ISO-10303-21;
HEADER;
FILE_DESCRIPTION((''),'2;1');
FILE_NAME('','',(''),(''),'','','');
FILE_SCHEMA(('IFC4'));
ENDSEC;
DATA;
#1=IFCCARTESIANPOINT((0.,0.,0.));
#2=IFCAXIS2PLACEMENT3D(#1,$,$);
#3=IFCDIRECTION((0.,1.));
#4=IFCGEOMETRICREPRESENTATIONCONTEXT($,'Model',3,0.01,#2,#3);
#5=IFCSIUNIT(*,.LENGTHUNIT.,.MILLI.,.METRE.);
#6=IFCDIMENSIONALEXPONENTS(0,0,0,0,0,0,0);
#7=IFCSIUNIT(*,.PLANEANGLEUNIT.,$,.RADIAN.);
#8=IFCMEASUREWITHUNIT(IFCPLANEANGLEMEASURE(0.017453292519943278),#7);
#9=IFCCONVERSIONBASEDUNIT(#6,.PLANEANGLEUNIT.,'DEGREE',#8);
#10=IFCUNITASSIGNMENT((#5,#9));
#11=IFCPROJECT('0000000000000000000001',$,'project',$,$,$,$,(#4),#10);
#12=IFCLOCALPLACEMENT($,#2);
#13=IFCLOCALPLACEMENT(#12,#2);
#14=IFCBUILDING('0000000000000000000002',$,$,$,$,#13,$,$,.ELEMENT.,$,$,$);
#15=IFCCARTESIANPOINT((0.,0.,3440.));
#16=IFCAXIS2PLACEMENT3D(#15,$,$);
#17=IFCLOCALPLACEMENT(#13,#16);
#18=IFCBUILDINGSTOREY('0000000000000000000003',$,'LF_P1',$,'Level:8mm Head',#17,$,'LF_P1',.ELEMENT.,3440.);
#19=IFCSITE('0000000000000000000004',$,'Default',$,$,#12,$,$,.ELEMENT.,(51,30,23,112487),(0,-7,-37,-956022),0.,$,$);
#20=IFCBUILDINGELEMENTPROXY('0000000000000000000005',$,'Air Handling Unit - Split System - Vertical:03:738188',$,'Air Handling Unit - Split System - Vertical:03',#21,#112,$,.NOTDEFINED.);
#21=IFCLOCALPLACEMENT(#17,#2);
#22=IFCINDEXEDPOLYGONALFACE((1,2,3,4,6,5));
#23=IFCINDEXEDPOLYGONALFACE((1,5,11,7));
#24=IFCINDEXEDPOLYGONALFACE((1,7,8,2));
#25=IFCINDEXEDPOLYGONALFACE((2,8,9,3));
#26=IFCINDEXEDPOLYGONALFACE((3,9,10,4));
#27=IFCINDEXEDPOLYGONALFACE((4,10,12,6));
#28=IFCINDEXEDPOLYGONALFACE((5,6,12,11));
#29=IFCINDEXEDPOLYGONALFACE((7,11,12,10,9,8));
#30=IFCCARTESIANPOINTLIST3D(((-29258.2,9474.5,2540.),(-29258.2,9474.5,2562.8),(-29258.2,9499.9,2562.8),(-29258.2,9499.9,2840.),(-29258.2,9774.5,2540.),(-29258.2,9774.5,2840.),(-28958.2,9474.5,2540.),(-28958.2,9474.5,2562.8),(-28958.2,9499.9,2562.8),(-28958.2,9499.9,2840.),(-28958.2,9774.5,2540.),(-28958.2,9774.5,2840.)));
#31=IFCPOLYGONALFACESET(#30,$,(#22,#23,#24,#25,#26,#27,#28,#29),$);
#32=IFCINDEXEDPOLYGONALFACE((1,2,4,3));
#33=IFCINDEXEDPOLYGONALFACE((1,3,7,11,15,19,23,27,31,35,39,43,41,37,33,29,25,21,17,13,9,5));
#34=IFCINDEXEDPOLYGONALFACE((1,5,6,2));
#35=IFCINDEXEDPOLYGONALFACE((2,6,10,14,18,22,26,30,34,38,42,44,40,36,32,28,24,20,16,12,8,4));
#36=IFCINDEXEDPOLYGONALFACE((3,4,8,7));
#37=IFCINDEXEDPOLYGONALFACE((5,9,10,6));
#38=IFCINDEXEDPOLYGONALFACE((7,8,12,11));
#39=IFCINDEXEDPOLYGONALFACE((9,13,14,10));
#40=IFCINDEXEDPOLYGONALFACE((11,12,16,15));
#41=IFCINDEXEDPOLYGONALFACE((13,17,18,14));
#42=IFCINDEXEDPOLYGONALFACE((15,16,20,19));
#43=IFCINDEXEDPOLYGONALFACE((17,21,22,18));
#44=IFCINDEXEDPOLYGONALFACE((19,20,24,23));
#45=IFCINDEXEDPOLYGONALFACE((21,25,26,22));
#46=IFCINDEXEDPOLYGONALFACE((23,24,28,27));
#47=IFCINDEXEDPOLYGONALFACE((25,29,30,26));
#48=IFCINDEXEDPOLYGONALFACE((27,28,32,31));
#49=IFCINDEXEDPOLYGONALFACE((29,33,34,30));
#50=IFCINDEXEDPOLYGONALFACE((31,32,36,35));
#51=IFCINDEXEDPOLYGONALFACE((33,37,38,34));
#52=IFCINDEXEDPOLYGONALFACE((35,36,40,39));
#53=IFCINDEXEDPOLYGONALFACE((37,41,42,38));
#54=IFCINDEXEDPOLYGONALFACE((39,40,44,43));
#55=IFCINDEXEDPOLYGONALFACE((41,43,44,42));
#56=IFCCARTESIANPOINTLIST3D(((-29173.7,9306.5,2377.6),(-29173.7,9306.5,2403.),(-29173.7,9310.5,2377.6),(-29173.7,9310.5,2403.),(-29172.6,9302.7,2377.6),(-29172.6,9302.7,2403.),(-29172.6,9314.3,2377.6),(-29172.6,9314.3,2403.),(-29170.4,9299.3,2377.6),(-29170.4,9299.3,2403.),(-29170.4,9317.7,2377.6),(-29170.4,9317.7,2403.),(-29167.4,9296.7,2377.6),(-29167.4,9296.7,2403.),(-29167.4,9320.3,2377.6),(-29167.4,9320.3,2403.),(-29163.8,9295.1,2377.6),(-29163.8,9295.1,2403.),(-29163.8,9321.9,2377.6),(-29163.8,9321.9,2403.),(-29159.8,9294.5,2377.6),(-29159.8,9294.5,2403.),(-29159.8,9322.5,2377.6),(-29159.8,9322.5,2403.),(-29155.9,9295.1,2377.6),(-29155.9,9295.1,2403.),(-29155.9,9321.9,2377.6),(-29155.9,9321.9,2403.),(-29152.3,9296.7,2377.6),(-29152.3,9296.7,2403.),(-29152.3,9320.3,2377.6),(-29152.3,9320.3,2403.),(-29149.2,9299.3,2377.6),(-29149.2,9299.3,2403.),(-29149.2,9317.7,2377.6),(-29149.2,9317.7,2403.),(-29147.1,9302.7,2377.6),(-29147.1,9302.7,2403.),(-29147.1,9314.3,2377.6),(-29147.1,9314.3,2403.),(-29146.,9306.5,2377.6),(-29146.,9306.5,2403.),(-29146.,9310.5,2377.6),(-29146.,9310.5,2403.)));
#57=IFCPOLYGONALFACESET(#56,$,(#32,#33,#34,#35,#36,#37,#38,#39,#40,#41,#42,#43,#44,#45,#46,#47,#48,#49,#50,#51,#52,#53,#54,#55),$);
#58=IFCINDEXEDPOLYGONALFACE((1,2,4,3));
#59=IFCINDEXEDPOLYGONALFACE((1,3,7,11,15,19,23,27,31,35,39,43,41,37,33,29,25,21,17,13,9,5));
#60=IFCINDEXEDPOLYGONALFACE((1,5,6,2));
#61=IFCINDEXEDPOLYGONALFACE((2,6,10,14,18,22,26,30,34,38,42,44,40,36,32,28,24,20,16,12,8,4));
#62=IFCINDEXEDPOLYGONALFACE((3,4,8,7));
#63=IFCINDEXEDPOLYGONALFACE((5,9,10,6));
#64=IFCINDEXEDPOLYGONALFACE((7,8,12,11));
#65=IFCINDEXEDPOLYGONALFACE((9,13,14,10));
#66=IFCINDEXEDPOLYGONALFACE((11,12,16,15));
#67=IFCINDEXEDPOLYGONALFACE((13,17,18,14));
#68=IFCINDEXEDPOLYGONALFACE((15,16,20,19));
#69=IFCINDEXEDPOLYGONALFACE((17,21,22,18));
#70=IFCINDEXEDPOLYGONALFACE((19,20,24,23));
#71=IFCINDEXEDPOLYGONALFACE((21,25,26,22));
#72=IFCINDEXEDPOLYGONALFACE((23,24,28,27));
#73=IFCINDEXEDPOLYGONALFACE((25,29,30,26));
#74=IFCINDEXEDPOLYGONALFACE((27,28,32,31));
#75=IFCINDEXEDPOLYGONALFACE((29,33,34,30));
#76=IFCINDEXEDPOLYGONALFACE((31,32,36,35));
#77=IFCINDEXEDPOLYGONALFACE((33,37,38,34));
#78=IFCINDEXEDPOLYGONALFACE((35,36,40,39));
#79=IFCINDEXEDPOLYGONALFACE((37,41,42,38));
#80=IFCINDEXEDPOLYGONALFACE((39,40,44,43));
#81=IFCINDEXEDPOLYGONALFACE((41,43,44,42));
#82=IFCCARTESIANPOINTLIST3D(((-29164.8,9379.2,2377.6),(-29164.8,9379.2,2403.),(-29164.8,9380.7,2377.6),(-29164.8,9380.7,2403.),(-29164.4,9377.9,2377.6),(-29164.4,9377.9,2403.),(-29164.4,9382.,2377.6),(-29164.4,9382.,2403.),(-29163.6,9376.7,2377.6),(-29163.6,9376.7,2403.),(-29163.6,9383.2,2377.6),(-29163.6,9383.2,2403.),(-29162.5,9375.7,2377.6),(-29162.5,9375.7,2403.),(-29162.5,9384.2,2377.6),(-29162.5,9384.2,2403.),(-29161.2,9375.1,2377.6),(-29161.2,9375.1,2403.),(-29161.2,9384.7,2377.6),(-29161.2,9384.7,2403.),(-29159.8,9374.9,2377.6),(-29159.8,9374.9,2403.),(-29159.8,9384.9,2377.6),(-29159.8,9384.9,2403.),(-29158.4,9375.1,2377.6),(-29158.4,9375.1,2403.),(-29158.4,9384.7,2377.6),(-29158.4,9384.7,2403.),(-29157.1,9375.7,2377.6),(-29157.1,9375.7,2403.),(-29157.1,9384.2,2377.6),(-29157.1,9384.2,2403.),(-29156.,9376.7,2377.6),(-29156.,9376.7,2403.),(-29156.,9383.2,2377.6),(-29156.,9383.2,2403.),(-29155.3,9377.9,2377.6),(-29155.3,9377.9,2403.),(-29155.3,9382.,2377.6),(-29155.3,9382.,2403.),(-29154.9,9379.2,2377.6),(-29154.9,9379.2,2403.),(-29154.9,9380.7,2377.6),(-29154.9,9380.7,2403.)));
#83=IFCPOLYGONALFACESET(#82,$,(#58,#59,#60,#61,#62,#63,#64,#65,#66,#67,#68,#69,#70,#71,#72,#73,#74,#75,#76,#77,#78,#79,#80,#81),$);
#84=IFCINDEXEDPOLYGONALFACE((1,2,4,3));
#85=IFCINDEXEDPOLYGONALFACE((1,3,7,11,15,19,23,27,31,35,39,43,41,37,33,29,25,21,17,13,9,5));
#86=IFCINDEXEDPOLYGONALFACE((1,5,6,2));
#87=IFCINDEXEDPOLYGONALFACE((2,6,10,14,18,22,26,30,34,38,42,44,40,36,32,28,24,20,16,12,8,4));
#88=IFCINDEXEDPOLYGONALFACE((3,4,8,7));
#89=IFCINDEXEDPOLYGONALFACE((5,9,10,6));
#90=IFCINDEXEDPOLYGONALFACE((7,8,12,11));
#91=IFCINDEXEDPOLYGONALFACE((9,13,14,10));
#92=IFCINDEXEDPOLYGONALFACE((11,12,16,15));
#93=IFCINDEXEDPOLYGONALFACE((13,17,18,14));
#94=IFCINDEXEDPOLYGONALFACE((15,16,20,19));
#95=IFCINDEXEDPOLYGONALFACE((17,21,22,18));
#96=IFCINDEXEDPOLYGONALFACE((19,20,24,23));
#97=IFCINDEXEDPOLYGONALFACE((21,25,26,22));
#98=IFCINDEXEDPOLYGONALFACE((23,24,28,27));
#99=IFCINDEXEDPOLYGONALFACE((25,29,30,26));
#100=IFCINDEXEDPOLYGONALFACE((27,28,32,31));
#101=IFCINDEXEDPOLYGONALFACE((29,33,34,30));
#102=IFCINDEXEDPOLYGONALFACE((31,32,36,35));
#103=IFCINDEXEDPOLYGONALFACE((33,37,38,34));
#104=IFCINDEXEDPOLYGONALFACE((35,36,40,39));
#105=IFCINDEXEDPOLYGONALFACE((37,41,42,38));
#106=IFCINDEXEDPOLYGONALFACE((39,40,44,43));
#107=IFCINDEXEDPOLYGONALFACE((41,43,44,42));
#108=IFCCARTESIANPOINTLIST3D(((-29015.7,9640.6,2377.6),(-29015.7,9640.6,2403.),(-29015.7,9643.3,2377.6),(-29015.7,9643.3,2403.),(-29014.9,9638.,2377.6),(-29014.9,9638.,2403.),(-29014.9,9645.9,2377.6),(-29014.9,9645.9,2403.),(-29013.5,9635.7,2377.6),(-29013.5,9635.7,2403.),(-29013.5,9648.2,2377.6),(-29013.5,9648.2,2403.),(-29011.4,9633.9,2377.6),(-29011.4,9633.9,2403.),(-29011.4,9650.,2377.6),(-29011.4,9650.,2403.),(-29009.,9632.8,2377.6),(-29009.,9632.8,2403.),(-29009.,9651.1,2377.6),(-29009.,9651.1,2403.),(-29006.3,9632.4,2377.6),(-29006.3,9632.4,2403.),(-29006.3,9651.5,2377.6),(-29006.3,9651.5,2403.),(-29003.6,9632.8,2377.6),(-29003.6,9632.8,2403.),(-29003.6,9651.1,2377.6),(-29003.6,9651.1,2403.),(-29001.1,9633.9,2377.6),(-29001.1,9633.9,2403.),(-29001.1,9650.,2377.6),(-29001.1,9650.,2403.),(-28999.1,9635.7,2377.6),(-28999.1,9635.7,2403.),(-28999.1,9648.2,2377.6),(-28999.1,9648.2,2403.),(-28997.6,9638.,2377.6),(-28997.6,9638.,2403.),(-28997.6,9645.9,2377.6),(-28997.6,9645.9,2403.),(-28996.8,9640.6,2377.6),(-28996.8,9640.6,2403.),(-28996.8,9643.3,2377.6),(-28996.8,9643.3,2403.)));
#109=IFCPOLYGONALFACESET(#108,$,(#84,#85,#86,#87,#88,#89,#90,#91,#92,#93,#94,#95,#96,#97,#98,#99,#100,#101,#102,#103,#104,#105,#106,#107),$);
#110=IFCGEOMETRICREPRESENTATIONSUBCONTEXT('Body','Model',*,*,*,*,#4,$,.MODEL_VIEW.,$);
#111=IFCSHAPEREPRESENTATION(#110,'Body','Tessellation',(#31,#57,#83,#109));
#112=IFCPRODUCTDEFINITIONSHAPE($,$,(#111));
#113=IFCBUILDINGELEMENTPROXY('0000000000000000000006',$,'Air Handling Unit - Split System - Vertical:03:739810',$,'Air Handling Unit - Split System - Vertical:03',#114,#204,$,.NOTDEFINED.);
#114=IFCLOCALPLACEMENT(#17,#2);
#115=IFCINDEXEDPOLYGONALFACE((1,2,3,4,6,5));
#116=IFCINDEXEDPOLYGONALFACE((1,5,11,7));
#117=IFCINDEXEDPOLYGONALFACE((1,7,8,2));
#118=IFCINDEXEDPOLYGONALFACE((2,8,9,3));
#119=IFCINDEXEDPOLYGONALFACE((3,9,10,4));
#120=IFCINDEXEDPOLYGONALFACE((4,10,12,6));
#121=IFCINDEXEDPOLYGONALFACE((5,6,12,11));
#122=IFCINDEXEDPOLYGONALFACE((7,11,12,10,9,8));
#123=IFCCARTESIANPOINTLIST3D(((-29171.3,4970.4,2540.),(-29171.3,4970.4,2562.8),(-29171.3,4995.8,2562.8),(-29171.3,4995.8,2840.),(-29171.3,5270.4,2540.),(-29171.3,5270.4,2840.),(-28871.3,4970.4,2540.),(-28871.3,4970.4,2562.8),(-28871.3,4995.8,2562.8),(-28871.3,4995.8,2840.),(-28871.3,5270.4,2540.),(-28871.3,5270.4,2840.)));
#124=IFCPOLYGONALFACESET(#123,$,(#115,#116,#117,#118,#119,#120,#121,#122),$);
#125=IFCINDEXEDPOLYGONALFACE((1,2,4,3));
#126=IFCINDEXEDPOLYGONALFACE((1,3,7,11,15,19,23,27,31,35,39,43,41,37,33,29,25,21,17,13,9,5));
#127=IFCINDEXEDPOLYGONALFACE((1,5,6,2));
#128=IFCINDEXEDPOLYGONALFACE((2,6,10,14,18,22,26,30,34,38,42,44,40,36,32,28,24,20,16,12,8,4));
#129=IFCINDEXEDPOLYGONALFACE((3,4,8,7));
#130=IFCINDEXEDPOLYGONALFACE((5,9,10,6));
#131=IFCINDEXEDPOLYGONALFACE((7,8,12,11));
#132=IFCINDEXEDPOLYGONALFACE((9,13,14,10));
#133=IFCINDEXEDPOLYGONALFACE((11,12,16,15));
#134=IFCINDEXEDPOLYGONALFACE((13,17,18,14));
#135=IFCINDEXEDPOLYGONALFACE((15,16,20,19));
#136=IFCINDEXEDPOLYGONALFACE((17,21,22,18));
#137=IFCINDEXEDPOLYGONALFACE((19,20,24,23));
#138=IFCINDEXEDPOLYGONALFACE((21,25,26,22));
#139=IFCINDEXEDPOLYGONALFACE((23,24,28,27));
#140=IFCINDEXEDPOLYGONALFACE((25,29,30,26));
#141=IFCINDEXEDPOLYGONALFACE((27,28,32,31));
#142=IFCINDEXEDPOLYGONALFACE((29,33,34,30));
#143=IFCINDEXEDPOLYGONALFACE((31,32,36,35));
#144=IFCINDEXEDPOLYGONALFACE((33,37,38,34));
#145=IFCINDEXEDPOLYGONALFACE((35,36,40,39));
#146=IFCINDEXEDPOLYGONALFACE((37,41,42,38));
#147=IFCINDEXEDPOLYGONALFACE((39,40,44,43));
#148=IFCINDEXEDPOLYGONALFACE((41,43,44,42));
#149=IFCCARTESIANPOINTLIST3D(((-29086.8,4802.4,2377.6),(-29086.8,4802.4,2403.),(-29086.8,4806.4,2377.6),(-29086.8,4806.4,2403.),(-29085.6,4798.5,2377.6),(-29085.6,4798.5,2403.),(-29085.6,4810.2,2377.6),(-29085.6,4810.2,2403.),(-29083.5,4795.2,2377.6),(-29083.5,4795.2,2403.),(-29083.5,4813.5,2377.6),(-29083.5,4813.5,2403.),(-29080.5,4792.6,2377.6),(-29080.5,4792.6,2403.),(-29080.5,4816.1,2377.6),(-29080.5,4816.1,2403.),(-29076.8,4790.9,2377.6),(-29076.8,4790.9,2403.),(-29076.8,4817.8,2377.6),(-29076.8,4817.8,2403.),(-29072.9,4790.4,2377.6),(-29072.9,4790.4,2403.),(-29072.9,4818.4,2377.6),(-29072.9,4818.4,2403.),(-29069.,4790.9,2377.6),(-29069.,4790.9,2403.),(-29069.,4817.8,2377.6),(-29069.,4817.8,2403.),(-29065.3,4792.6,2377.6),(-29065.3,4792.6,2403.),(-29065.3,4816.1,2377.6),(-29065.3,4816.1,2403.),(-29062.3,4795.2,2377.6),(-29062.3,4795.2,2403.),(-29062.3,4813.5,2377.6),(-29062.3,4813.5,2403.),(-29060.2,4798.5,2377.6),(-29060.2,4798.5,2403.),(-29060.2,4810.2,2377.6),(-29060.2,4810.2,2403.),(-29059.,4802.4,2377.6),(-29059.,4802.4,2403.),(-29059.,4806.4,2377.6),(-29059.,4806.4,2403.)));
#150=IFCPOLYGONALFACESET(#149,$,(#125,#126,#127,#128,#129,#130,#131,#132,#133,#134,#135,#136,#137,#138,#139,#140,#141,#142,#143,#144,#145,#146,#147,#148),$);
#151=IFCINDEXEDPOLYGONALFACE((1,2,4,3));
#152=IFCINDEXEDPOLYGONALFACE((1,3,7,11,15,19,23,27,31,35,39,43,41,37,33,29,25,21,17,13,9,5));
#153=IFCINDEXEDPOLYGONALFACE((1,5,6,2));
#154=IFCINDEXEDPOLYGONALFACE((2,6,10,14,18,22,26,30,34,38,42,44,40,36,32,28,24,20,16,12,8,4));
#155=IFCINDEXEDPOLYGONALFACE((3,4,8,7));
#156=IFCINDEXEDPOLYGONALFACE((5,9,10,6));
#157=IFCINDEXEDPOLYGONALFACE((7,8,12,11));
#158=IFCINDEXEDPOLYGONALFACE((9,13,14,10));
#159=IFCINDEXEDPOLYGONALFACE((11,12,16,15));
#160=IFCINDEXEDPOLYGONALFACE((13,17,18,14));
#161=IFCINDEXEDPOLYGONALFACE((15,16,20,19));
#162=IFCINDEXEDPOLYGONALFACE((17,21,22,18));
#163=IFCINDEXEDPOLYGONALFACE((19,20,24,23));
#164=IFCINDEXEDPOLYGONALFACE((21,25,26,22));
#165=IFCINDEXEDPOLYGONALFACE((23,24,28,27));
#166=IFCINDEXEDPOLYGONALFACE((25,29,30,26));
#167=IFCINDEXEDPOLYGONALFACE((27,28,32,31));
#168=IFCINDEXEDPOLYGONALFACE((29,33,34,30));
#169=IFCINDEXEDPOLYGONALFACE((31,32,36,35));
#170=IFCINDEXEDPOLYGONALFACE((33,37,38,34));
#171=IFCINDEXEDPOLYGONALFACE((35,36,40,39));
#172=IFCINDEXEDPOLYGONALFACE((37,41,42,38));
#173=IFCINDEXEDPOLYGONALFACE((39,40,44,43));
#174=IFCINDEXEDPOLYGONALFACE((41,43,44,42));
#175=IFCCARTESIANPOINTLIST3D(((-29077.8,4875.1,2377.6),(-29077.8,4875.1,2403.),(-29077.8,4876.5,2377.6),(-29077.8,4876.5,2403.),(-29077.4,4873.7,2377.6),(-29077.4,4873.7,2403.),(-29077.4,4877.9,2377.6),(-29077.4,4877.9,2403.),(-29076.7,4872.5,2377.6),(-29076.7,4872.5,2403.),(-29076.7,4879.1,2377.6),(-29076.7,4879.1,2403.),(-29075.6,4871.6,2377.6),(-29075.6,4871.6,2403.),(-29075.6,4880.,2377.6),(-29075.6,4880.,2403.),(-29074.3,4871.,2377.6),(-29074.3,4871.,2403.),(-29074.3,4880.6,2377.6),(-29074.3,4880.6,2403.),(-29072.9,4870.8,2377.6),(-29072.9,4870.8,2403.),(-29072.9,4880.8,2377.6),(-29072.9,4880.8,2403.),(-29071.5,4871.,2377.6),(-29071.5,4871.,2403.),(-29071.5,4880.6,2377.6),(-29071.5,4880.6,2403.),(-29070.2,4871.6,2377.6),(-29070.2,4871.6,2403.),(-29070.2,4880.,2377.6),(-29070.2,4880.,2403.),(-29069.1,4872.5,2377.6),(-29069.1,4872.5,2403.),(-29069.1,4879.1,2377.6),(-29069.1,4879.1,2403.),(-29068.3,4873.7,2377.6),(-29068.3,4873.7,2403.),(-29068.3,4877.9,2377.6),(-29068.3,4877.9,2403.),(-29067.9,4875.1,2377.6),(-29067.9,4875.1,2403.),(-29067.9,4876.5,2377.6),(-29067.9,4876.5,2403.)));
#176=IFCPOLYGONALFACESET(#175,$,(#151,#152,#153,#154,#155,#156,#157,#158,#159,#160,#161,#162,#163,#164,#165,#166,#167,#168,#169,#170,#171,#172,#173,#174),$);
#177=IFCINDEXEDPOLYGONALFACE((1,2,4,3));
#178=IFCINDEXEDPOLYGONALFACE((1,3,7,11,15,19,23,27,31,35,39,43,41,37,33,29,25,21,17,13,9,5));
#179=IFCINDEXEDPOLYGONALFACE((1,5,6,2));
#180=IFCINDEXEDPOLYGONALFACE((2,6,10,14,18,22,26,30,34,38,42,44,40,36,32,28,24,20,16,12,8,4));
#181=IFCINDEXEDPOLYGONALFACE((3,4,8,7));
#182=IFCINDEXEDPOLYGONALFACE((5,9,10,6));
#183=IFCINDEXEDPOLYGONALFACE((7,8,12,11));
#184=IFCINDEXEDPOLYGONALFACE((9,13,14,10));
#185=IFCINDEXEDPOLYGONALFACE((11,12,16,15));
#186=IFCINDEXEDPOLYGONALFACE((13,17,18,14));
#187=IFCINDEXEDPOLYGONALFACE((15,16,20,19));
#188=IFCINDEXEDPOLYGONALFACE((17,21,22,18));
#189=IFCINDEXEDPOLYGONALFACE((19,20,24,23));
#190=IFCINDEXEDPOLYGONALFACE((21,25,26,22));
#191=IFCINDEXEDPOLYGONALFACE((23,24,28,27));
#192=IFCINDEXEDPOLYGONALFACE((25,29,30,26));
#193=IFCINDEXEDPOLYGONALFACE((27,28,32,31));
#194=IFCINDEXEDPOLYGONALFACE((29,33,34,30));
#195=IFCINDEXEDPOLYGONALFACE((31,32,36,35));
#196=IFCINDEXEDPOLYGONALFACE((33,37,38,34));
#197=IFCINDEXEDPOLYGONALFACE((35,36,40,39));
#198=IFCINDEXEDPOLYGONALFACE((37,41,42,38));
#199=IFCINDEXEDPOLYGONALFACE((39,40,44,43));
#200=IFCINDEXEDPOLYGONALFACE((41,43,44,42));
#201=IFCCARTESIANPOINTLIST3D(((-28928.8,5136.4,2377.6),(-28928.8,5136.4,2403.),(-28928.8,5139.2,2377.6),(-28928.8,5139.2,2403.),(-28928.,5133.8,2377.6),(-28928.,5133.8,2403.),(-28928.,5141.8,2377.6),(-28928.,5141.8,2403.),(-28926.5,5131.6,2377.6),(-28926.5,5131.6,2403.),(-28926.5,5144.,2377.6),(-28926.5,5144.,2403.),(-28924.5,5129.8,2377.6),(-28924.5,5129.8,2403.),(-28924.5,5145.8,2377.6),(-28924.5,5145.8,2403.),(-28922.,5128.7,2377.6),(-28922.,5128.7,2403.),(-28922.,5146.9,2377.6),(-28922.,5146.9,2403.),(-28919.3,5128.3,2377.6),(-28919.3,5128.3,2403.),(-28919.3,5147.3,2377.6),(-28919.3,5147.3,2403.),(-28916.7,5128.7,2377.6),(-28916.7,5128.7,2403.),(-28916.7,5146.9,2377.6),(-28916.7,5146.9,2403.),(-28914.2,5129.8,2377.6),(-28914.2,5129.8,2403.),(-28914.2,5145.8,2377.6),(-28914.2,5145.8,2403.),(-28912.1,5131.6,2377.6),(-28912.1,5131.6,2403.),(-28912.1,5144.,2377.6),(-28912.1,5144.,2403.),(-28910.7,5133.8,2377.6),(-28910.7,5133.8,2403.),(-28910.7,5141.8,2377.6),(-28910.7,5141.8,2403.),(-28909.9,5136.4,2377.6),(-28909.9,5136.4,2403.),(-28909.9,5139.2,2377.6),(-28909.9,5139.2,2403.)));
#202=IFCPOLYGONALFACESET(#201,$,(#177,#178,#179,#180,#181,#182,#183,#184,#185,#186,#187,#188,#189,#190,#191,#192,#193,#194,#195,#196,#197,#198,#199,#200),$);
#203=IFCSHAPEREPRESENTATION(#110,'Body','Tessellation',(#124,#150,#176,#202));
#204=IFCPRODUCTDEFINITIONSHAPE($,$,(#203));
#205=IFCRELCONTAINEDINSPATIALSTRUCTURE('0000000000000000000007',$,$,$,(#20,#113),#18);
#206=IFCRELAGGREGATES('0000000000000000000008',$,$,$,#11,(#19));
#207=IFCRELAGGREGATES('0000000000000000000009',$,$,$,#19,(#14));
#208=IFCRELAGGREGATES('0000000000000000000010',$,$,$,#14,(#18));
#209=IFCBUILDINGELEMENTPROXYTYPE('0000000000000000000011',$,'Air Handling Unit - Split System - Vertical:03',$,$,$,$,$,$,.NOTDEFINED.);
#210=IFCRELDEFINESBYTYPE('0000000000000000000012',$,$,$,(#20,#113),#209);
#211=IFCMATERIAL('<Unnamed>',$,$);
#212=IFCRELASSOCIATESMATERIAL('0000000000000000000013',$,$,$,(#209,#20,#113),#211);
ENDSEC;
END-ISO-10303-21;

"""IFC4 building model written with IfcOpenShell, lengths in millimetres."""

from ifc_helpers import new_model, entity, si_unit, converted_unit, direction, frame, origin, place, context, subcontext, project, spatial, arc, indexed_curve, outline, extrude, source, transform, mapped, material, type_object, type_shapes, element, save


model = new_model("IFC4")

# Units and contexts
model_context = context("Model", 3, precision=0.01, world=origin(), true_north=direction((0.0, 1.0)))
body_context = subcontext(model_context, "Body", "Model", "MODEL_VIEW")
ifc_project = project(units=[si_unit("LENGTHUNIT", "METRE", prefix="MILLI"), converted_unit("PLANEANGLEUNIT", "DEGREE", entity("IfcPlaneAngleMeasure", 0.017453292519943278), si_unit("PLANEANGLEUNIT", "RADIAN"), dimensions=[0, 0, 0, 0, 0, 0, 0])], contexts=[model_context])

# Site, building, storey
site_placement = place(None, origin())
site = spatial("IfcSite", under=ifc_project, at=site_placement, Name="Default", CompositionType="ELEMENT", RefLatitude=(51, 30, 23, 112487), RefLongitude=(0, -7, -37, -956022), RefElevation=0.0)
building_placement = place(site_placement, origin())
building = spatial("IfcBuilding", under=site, at=building_placement, CompositionType="ELEMENT")
storey_placement = place(building_placement, frame((0.0, 0.0, 3440.0)))
storey = spatial("IfcBuildingStorey", under=building, at=storey_placement, Name="LF_P1", ObjectType="Level:8mm Head", LongName="LF_P1", CompositionType="ELEMENT", Elevation=3440.0)

# Shared definitions
ifc_material = material(Name="<Unnamed>")

# Building element proxies
building_element_proxy_type_1 = type_object("IfcBuildingElementProxyType", Name="Air Handling Unit - Split System - Vertical:03", PredefinedType="NOTDEFINED", material=ifc_material)
shared_shape_1 = source(origin(), body_context, "Body", "SweptSolid", [
    extrude(outline(indexed_curve([(-191.5, -107.6), (108.5, -107.6), (108.5, -84.8), (83.1, -84.8), (83.1, 192.4), (-191.5, 192.4), (-191.5, -107.6)], self_intersect=False)), frame((-150.0, 42.4, 191.5), z_axis=(1.0, 0.0, 0.0), x_axis=(0.0, 0.0, 1.0)), (0.0, 0.0, 1.0), 300.0),
    extrude(outline(indexed_curve([(-14.0, 0.0), (0.0, -14.0), (14.0, 0.0), (0.0, 14.0)], segments=[arc(1, 2, 3), arc(3, 4, 1)], self_intersect=False)), frame((51.6, 287.0, 466.0), z_axis=(0.0, 1.0, 0.0), x_axis=(0.0, 0.0, -1.0)), (0.0, 0.0, 1.0), 25.4),
    extrude(outline(indexed_curve([(-5.0, 0.0), (0.0, -5.0), (5.0, 0.0), (0.0, 5.0)], segments=[arc(1, 2, 3), arc(3, 4, 1)], self_intersect=False)), frame((51.6, 287.0, 394.6), z_axis=(0.0, 1.0, 0.0), x_axis=(0.0, 0.0, -1.0)), (0.0, 0.0, 1.0), 25.4),
    extrude(outline(indexed_curve([(-9.5, 0.0), (0.0, -9.5), (9.5, 0.0), (0.0, 9.5)], segments=[arc(1, 2, 3), arc(3, 4, 1)], self_intersect=False)), frame((-102.0, 287.0, 132.6), z_axis=(0.0, 1.0, 0.0), x_axis=(0.0, 0.0, -1.0)), (0.0, 0.0, 1.0), 25.4),
])
type_shapes(building_element_proxy_type_1, [shared_shape_1])
for number, where, z_axis, x_axis, name in (
    (1, (-29108.2, 9774.5, 2690.0), (0.0, -1.0, 0.0), (-1.0, 0.0, 0.0), "Air Handling Unit - Split System - Vertical:03:738188"),
    (2, (-29021.3, 5270.4, 2690.0), (0.0, -1.0, 0.0), (-1.0, 0.0, 0.0), "Air Handling Unit - Split System - Vertical:03:739810"),
):
    element("IfcBuildingElementProxy", number, at=place(storey_placement, frame(where, z_axis=z_axis, x_axis=x_axis)), inside=storey, type_object=building_element_proxy_type_1, material=ifc_material, Name=name, ObjectType="Air Handling Unit - Split System - Vertical:03", PredefinedType="NOTDEFINED", context=body_context, shape_type="MappedRepresentation", body=[
        mapped(shared_shape_1, transform((0.0, 0.0, 0.0), scale=1.0)),
    ])

save(model, "model.ifc")
